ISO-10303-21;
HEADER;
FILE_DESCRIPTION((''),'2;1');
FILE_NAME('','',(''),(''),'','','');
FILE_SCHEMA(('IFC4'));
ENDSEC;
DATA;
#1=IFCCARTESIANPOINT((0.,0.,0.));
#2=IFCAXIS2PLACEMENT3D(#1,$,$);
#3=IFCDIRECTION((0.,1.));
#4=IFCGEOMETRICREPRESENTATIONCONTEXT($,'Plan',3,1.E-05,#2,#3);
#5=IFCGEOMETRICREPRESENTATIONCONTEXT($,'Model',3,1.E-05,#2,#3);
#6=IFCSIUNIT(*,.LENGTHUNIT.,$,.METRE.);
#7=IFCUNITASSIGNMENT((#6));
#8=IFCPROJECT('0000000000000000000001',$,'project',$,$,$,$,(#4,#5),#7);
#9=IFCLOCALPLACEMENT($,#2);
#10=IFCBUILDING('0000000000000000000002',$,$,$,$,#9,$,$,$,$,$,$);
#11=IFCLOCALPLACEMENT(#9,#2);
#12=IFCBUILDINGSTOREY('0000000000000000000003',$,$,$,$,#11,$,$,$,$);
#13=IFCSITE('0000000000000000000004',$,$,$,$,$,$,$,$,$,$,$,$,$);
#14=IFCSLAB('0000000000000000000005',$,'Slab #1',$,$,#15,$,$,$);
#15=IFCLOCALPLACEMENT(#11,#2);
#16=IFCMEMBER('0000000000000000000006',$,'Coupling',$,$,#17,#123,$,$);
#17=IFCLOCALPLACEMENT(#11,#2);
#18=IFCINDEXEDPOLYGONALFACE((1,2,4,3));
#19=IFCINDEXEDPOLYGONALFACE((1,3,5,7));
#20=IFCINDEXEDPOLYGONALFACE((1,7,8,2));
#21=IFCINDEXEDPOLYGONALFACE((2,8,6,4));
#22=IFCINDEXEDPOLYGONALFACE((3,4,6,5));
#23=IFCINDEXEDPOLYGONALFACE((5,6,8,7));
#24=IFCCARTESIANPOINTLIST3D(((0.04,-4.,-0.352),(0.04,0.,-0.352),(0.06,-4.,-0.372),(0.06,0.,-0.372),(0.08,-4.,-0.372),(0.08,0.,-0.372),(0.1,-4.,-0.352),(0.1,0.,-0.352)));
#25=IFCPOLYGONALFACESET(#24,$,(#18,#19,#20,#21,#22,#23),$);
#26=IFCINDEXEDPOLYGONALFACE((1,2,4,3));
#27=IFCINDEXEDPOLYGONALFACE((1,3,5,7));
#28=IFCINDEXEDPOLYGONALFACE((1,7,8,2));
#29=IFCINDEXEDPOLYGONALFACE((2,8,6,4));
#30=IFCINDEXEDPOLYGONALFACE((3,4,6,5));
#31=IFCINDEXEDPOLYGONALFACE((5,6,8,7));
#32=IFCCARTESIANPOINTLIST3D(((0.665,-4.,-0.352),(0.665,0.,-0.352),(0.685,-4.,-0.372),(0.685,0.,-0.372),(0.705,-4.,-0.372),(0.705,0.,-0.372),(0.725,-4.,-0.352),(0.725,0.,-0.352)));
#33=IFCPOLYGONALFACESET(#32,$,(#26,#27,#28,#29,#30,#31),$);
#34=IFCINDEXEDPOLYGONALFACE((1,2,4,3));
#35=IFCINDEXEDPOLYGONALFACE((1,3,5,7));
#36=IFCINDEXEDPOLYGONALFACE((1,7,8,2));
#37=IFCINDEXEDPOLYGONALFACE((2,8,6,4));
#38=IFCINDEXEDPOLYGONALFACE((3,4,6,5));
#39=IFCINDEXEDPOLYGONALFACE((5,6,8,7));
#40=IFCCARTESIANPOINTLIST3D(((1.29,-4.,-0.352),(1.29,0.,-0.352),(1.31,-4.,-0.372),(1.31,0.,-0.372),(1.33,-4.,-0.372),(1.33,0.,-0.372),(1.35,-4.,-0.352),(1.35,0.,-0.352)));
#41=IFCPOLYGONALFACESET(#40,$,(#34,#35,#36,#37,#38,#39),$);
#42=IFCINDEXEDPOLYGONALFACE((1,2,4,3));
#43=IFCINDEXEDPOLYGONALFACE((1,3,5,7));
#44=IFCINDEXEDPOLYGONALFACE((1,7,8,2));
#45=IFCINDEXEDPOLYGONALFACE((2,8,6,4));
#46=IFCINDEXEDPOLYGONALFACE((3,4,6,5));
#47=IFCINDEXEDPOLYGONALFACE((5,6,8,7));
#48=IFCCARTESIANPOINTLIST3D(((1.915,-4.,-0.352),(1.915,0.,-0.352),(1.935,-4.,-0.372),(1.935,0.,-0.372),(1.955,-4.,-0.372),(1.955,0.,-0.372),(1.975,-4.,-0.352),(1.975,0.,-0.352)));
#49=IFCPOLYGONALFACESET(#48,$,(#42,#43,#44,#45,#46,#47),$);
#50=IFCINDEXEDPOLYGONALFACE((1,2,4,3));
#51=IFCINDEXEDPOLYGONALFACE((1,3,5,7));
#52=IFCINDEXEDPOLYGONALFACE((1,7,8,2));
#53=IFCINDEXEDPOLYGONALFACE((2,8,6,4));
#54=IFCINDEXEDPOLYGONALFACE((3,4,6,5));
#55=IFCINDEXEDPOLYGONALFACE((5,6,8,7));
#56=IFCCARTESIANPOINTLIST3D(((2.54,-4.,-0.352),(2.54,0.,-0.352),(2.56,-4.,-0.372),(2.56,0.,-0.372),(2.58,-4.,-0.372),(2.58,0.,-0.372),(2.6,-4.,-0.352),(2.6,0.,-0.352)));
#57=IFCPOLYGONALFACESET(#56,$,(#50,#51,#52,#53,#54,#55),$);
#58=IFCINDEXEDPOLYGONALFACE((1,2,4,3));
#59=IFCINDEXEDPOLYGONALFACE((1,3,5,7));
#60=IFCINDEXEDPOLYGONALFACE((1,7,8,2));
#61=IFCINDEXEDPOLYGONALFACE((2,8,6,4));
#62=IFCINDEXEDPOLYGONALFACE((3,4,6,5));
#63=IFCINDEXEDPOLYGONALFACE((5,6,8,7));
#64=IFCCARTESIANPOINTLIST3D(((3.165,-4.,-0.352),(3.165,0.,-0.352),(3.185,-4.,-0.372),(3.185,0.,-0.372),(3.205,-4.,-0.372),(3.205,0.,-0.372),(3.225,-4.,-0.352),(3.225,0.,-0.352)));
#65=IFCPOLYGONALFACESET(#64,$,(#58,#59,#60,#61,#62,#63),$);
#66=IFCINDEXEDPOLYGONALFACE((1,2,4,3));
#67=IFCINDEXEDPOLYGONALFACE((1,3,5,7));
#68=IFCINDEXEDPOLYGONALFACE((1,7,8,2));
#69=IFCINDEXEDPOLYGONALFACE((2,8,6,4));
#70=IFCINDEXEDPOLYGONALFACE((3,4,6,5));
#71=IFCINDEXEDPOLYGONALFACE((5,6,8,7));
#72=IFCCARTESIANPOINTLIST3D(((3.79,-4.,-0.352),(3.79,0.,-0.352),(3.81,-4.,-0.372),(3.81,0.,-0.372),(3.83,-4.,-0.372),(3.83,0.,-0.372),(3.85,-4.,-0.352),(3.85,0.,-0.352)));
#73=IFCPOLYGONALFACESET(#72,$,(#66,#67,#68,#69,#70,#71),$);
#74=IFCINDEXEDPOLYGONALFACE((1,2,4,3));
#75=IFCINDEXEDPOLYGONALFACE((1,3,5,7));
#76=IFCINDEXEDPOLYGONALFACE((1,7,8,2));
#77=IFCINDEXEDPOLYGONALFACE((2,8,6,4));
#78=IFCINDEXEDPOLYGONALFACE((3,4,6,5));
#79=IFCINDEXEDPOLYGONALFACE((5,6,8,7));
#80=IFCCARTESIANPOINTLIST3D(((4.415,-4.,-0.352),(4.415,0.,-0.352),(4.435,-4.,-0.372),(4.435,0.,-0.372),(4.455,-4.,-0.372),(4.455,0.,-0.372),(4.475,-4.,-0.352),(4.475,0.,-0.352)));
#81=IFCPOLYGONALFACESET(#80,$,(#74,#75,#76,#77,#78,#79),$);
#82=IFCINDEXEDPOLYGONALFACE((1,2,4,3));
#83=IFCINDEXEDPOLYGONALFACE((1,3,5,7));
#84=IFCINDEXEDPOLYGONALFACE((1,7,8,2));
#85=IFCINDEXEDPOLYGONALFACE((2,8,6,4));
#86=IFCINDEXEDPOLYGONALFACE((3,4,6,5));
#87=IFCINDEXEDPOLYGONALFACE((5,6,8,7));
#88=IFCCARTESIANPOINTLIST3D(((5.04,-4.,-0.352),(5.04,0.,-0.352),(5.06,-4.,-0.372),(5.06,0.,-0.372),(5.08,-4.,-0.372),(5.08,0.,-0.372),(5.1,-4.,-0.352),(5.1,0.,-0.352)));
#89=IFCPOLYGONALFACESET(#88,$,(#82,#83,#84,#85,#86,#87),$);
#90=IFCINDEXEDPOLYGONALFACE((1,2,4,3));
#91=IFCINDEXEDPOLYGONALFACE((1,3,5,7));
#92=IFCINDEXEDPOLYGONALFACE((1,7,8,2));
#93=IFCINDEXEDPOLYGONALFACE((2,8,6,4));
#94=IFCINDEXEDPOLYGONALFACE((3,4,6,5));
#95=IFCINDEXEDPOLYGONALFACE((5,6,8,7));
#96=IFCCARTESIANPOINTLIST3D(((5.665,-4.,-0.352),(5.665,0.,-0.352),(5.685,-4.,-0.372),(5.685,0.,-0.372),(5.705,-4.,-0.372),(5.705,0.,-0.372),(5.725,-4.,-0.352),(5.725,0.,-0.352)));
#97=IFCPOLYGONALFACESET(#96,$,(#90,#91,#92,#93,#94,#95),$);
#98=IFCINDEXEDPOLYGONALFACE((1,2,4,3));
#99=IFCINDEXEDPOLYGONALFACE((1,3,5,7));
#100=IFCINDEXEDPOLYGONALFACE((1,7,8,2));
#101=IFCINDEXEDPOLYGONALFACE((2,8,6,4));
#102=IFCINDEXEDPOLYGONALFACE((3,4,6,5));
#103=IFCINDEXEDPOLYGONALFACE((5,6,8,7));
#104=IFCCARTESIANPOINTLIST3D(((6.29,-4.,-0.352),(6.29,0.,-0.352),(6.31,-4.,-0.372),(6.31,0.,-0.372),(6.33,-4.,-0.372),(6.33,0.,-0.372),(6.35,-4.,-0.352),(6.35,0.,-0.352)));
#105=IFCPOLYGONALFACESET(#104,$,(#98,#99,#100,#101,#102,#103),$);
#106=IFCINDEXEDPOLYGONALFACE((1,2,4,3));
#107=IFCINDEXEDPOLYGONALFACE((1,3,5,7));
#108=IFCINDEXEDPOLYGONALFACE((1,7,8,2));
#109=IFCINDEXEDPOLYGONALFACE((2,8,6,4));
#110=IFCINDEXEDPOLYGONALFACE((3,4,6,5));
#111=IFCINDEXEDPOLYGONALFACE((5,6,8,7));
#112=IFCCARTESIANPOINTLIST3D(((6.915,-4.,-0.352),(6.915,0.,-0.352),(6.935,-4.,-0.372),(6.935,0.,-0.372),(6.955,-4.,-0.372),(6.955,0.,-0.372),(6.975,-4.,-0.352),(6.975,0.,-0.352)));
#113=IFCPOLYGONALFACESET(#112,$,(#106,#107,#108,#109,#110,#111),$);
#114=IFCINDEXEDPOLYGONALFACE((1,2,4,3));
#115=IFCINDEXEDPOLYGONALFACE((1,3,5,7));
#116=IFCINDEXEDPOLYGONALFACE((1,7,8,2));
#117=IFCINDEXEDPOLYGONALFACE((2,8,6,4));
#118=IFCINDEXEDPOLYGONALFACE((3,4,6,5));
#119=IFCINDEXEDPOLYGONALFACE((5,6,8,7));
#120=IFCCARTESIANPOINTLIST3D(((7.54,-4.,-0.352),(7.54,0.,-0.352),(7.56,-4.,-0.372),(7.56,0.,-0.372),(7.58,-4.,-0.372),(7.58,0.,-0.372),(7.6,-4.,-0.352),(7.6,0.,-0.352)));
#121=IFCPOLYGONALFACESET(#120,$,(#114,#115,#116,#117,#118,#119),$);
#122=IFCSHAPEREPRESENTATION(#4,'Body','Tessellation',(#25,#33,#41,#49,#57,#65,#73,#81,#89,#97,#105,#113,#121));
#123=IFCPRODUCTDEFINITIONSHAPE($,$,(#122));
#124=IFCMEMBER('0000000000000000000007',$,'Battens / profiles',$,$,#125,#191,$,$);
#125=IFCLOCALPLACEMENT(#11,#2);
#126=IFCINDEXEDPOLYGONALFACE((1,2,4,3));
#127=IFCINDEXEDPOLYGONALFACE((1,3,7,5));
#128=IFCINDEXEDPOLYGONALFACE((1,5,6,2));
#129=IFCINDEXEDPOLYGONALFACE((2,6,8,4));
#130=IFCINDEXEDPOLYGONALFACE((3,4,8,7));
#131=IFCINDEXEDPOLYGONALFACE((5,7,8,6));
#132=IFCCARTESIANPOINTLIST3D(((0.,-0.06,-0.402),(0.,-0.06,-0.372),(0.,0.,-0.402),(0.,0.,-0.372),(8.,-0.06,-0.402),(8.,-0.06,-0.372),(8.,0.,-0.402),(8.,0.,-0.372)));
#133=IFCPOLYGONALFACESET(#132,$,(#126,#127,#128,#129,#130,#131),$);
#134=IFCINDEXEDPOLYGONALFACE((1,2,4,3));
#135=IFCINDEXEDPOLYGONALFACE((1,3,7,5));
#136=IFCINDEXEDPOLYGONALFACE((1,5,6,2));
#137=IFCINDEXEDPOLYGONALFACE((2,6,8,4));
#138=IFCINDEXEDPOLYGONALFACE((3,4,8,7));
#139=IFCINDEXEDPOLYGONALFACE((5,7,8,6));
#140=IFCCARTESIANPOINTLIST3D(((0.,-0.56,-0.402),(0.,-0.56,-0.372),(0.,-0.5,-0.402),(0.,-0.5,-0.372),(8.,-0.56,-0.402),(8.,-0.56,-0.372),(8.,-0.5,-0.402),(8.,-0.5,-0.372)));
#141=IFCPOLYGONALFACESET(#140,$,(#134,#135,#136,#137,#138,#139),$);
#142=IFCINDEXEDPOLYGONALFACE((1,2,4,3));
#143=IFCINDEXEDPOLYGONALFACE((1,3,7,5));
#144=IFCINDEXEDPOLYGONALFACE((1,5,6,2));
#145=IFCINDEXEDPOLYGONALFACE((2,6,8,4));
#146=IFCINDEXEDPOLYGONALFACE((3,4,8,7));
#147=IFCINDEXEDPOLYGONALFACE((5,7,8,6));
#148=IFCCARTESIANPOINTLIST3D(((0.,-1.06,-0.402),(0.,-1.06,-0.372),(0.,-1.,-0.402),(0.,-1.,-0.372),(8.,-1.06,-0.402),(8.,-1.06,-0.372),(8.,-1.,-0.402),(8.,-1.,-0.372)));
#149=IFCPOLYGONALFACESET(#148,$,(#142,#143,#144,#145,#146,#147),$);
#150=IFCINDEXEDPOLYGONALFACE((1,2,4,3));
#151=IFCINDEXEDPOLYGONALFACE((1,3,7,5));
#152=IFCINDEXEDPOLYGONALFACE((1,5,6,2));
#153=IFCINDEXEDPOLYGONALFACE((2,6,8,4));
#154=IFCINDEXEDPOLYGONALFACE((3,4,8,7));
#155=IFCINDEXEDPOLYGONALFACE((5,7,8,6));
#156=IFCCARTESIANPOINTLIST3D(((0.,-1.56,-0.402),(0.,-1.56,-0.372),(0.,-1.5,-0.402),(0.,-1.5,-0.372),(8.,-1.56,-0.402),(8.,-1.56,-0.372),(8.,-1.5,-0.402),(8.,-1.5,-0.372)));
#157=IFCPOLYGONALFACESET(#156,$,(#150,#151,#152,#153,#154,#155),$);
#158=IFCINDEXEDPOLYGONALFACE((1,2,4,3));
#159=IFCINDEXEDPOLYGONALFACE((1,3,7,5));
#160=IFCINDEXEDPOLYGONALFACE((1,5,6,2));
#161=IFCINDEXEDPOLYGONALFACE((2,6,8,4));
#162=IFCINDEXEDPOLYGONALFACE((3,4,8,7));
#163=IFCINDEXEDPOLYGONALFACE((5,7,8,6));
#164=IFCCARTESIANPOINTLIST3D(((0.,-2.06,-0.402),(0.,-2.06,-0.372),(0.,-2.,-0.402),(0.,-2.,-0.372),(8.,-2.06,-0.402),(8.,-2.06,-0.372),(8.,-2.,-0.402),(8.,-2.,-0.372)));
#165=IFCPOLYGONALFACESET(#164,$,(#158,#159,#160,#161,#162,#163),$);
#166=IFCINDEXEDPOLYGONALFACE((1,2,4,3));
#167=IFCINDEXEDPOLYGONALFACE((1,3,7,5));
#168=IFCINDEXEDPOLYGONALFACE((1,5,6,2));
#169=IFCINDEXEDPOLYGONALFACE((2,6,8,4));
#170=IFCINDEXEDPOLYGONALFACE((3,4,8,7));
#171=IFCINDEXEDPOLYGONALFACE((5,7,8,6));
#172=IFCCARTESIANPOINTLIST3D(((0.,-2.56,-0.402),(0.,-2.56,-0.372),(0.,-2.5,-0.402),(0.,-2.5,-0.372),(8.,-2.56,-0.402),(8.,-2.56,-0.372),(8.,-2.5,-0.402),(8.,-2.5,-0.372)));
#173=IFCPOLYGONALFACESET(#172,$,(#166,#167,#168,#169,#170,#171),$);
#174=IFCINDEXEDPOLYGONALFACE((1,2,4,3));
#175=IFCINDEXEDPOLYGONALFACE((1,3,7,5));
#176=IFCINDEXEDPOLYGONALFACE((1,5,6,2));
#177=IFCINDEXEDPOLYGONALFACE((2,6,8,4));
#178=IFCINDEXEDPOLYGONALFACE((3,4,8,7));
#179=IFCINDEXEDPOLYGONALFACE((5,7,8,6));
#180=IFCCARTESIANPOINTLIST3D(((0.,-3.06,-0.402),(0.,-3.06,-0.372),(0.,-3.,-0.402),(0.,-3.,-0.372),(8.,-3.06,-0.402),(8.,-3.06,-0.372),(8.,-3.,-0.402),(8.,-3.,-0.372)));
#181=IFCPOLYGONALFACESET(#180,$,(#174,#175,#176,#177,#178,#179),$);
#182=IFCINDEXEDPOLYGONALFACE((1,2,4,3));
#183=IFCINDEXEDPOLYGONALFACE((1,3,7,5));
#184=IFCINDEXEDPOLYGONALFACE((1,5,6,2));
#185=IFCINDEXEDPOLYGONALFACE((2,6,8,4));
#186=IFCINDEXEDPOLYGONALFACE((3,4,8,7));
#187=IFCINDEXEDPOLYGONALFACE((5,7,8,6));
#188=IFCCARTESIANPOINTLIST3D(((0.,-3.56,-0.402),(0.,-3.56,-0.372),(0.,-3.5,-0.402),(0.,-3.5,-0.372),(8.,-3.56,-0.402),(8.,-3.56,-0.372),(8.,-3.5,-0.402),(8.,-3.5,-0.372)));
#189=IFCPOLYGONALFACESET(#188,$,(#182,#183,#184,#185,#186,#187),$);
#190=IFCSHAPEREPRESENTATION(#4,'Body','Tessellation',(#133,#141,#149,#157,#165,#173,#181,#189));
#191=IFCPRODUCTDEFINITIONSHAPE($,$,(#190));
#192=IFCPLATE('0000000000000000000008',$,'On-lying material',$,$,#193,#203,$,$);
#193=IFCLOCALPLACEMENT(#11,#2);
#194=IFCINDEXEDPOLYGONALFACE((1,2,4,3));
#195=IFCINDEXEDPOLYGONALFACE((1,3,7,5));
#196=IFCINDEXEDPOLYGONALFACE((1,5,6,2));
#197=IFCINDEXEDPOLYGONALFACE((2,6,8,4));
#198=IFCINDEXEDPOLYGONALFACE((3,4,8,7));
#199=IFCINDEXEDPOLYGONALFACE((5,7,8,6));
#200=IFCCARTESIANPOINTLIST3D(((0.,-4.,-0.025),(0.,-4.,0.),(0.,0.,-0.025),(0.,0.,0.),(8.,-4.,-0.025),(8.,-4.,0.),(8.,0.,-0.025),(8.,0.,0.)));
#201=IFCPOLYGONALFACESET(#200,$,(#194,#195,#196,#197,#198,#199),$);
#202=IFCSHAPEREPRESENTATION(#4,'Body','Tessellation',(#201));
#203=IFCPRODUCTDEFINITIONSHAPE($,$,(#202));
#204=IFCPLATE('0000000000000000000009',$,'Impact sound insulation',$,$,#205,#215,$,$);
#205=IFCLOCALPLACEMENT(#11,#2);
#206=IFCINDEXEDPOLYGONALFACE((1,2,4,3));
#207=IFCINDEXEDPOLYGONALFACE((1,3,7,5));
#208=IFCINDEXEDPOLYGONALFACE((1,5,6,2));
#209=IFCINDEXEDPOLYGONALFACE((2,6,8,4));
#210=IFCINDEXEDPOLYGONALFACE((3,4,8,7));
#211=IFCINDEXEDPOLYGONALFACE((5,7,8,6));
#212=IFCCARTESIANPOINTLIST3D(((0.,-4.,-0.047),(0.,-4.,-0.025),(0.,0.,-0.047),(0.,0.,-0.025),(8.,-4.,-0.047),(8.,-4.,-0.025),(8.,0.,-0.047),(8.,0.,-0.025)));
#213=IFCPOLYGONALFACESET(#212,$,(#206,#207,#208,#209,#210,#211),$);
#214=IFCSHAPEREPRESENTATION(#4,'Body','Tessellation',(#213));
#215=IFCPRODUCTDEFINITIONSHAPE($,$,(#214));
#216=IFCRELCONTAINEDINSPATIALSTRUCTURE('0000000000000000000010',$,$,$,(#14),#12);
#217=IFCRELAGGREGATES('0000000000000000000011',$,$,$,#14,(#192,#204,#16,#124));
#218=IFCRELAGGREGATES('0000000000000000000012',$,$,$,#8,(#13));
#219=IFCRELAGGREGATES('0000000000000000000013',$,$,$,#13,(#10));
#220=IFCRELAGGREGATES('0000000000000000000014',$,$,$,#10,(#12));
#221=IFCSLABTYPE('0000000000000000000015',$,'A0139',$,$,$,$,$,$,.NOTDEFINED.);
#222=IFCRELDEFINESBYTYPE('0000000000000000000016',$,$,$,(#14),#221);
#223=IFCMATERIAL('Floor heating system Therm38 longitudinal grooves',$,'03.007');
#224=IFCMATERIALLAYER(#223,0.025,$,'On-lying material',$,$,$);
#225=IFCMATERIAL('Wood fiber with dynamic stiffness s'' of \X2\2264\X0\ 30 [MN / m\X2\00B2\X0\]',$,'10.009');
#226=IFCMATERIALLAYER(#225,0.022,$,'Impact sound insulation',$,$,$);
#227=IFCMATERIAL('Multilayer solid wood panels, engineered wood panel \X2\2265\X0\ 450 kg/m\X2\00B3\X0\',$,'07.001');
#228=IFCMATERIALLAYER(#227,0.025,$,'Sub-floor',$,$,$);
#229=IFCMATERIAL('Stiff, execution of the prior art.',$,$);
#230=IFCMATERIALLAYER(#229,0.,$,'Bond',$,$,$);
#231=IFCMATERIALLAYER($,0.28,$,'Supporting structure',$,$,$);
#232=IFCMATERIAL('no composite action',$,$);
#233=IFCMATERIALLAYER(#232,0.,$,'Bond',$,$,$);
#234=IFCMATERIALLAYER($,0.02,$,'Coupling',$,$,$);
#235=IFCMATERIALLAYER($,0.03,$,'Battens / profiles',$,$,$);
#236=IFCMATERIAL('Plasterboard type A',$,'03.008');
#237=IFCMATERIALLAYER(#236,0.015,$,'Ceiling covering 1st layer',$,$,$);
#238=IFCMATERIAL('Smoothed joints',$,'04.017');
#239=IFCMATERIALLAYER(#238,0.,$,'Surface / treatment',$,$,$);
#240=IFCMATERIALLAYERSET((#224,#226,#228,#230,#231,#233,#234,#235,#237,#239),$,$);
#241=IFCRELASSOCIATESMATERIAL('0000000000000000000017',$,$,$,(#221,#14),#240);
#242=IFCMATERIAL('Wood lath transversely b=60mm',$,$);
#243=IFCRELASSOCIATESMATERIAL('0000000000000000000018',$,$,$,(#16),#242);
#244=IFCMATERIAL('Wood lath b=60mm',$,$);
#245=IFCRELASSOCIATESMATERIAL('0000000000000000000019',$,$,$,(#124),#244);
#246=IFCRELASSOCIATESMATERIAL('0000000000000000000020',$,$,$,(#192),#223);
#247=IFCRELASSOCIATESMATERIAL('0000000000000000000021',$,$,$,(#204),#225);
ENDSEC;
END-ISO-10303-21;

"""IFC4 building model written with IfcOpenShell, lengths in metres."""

from ifc_helpers import new_model, si_unit, direction, frame, frame_2d, origin, origin_with_axes, place, context, project, spatial, polyline, rectangle, outline, extrude, material, layer, layer_set, type_object, element, aggregate, save


model = new_model("IFC4")

# Units and contexts
plan_context = context("Plan", 3, precision=1e-05, world=origin(), true_north=direction((0.0, 1.0)))
model_context = context("Model", 3, precision=1e-05, world=origin(), true_north=direction((0.0, 1.0)))
ifc_project = project(units=[si_unit("LENGTHUNIT", "METRE")], contexts=[plan_context, model_context])

# Site, building, storey
site = spatial("IfcSite", under=ifc_project)
building_placement = place(None, origin())
building = spatial("IfcBuilding", under=site, at=building_placement)
storey_placement = place(building_placement, origin())
storey = spatial("IfcBuildingStorey", under=building, at=storey_placement)

# Slab, members, plates
ifc_material_1 = material(Name="Floor heating system Therm38 longitudinal grooves", Category="03.007")
ifc_layer_1 = layer(ifc_material_1, 0.025, Name="On-lying material")
ifc_material_2 = material(Name="Wood fiber with dynamic stiffness s' of ≤ 30 [MN / m²]", Category="10.009")
ifc_layer_2 = layer(ifc_material_2, 0.022, Name="Impact sound insulation")
ifc_material_3 = material(Name="Multilayer solid wood panels, engineered wood panel ≥ 450 kg/m³", Category="07.001")
ifc_layer_3 = layer(ifc_material_3, 0.025, Name="Sub-floor")
ifc_material_4 = material(Name="Stiff, execution of the prior art.")
ifc_layer_4 = layer(ifc_material_4, 0.0, Name="Bond")
ifc_layer_5 = layer(None, 0.28, Name="Supporting structure")
ifc_material_5 = material(Name="no composite action")
ifc_layer_6 = layer(ifc_material_5, 0.0, Name="Bond")
ifc_layer_7 = layer(None, 0.02, Name="Coupling")
ifc_layer_8 = layer(None, 0.03, Name="Battens / profiles")
ifc_material_6 = material(Name="Plasterboard type A", Category="03.008")
ifc_layer_9 = layer(ifc_material_6, 0.015, Name="Ceiling covering 1st layer")
ifc_material_7 = material(Name="Smoothed joints", Category="04.017")
ifc_layer_10 = layer(ifc_material_7, 0.0, Name="Surface / treatment")
ifc_layer_set = layer_set([ifc_layer_1, ifc_layer_2, ifc_layer_3, ifc_layer_4, ifc_layer_5, ifc_layer_6, ifc_layer_7, ifc_layer_8, ifc_layer_9, ifc_layer_10])
slab_type = type_object("IfcSlabType", Name="A0139", PredefinedType="NOTDEFINED", material=ifc_layer_set)
slab_placement = place(None, frame((0.0, 0.0, 0.0), z_axis=(0.0, 0.0, -1.0), x_axis=(1.0, 0.0, 0.0)))
slab = element("IfcSlab", 1, at=slab_placement, inside=storey, type_object=slab_type, material=ifc_layer_set, Name="Slab #1")
ifc_material_8 = material(Name="Wood lath transversely b=60mm")
member_1_placement = place(slab_placement, origin())
member_1 = element("IfcMember", 2, at=member_1_placement, material=ifc_material_8, Name="Coupling", context=plan_context, shape_type="SweptSolid", body=[
    extrude(outline(polyline([(0.0, 0.0), (0.06, 0.0), (0.04, 0.02), (0.02, 0.02), (0.0, 0.0)])), frame((0.04, 4.0, 0.352), z_axis=(0.0, -1.0, 0.0), x_axis=(1.0, 0.0, 0.0)), (0.0, 0.0, 1.0), 4.0),
    extrude(outline(polyline([(0.0, 0.0), (0.06, 0.0), (0.04, 0.02), (0.02, 0.02), (0.0, 0.0)])), frame((0.665, 4.0, 0.352), z_axis=(0.0, -1.0, 0.0), x_axis=(1.0, 0.0, 0.0)), (0.0, 0.0, 1.0), 4.0),
    extrude(outline(polyline([(0.0, 0.0), (0.06, 0.0), (0.04, 0.02), (0.02, 0.02), (0.0, 0.0)])), frame((1.29, 4.0, 0.352), z_axis=(0.0, -1.0, 0.0), x_axis=(1.0, 0.0, 0.0)), (0.0, 0.0, 1.0), 4.0),
    extrude(outline(polyline([(0.0, 0.0), (0.06, 0.0), (0.04, 0.02), (0.02, 0.02), (0.0, 0.0)])), frame((1.915, 4.0, 0.352), z_axis=(0.0, -1.0, 0.0), x_axis=(1.0, 0.0, 0.0)), (0.0, 0.0, 1.0), 4.0),
    extrude(outline(polyline([(0.0, 0.0), (0.06, 0.0), (0.04, 0.02), (0.02, 0.02), (0.0, 0.0)])), frame((2.54, 4.0, 0.352), z_axis=(0.0, -1.0, 0.0), x_axis=(1.0, 0.0, 0.0)), (0.0, 0.0, 1.0), 4.0),
    extrude(outline(polyline([(0.0, 0.0), (0.06, 0.0), (0.04, 0.02), (0.02, 0.02), (0.0, 0.0)])), frame((3.165, 4.0, 0.352), z_axis=(0.0, -1.0, 0.0), x_axis=(1.0, 0.0, 0.0)), (0.0, 0.0, 1.0), 4.0),
    extrude(outline(polyline([(0.0, 0.0), (0.06, 0.0), (0.04, 0.02), (0.02, 0.02), (0.0, 0.0)])), frame((3.79, 4.0, 0.352), z_axis=(0.0, -1.0, 0.0), x_axis=(1.0, 0.0, 0.0)), (0.0, 0.0, 1.0), 4.0),
    extrude(outline(polyline([(0.0, 0.0), (0.06, 0.0), (0.04, 0.02), (0.02, 0.02), (0.0, 0.0)])), frame((4.415, 4.0, 0.352), z_axis=(0.0, -1.0, 0.0), x_axis=(1.0, 0.0, 0.0)), (0.0, 0.0, 1.0), 4.0),
    extrude(outline(polyline([(0.0, 0.0), (0.06, 0.0), (0.04, 0.02), (0.02, 0.02), (0.0, 0.0)])), frame((5.04, 4.0, 0.352), z_axis=(0.0, -1.0, 0.0), x_axis=(1.0, 0.0, 0.0)), (0.0, 0.0, 1.0), 4.0),
    extrude(outline(polyline([(0.0, 0.0), (0.06, 0.0), (0.04, 0.02), (0.02, 0.02), (0.0, 0.0)])), frame((5.665, 4.0, 0.352), z_axis=(0.0, -1.0, 0.0), x_axis=(1.0, 0.0, 0.0)), (0.0, 0.0, 1.0), 4.0),
    extrude(outline(polyline([(0.0, 0.0), (0.06, 0.0), (0.04, 0.02), (0.02, 0.02), (0.0, 0.0)])), frame((6.29, 4.0, 0.352), z_axis=(0.0, -1.0, 0.0), x_axis=(1.0, 0.0, 0.0)), (0.0, 0.0, 1.0), 4.0),
    extrude(outline(polyline([(0.0, 0.0), (0.06, 0.0), (0.04, 0.02), (0.02, 0.02), (0.0, 0.0)])), frame((6.915, 4.0, 0.352), z_axis=(0.0, -1.0, 0.0), x_axis=(1.0, 0.0, 0.0)), (0.0, 0.0, 1.0), 4.0),
    extrude(outline(polyline([(0.0, 0.0), (0.06, 0.0), (0.04, 0.02), (0.02, 0.02), (0.0, 0.0)])), frame((7.54, 4.0, 0.352), z_axis=(0.0, -1.0, 0.0), x_axis=(1.0, 0.0, 0.0)), (0.0, 0.0, 1.0), 4.0),
])
ifc_material_9 = material(Name="Wood lath b=60mm")
member_2_placement = place(slab_placement, origin())
member_2 = element("IfcMember", 3, at=member_2_placement, material=ifc_material_9, Name="Battens / profiles", context=plan_context, shape_type="SweptSolid", body=[
    extrude(rectangle(XDim=0.06, YDim=0.03, at=frame_2d((0.03, 0.015), x_axis=(1.0, 0.0))), frame((0.0, 0.0, 0.372), z_axis=(1.0, 0.0, 0.0), x_axis=(0.0, 1.0, 0.0)), (0.0, 0.0, 1.0), 8.0),
    extrude(rectangle(XDim=0.06, YDim=0.03, at=frame_2d((0.03, 0.015), x_axis=(1.0, 0.0))), frame((0.0, 0.5, 0.372), z_axis=(1.0, 0.0, 0.0), x_axis=(0.0, 1.0, 0.0)), (0.0, 0.0, 1.0), 8.0),
    extrude(rectangle(XDim=0.06, YDim=0.03, at=frame_2d((0.03, 0.015), x_axis=(1.0, 0.0))), frame((0.0, 1.0, 0.372), z_axis=(1.0, 0.0, 0.0), x_axis=(0.0, 1.0, 0.0)), (0.0, 0.0, 1.0), 8.0),
    extrude(rectangle(XDim=0.06, YDim=0.03, at=frame_2d((0.03, 0.015), x_axis=(1.0, 0.0))), frame((0.0, 1.5, 0.372), z_axis=(1.0, 0.0, 0.0), x_axis=(0.0, 1.0, 0.0)), (0.0, 0.0, 1.0), 8.0),
    extrude(rectangle(XDim=0.06, YDim=0.03, at=frame_2d((0.03, 0.015), x_axis=(1.0, 0.0))), frame((0.0, 2.0, 0.372), z_axis=(1.0, 0.0, 0.0), x_axis=(0.0, 1.0, 0.0)), (0.0, 0.0, 1.0), 8.0),
    extrude(rectangle(XDim=0.06, YDim=0.03, at=frame_2d((0.03, 0.015), x_axis=(1.0, 0.0))), frame((0.0, 2.5, 0.372), z_axis=(1.0, 0.0, 0.0), x_axis=(0.0, 1.0, 0.0)), (0.0, 0.0, 1.0), 8.0),
    extrude(rectangle(XDim=0.06, YDim=0.03, at=frame_2d((0.03, 0.015), x_axis=(1.0, 0.0))), frame((0.0, 3.0, 0.372), z_axis=(1.0, 0.0, 0.0), x_axis=(0.0, 1.0, 0.0)), (0.0, 0.0, 1.0), 8.0),
    extrude(rectangle(XDim=0.06, YDim=0.03, at=frame_2d((0.03, 0.015), x_axis=(1.0, 0.0))), frame((0.0, 3.5, 0.372), z_axis=(1.0, 0.0, 0.0), x_axis=(0.0, 1.0, 0.0)), (0.0, 0.0, 1.0), 8.0),
])
plate_1_placement = place(slab_placement, origin())
plate_1 = element("IfcPlate", 4, at=plate_1_placement, material=ifc_material_1, Name="On-lying material", context=plan_context, shape_type="SweptSolid", body=[
    extrude(rectangle(XDim=8.0, YDim=4.0, at=frame_2d((4.0, 2.0), x_axis=(1.0, 0.0))), origin_with_axes(), (0.0, 0.0, 1.0), 0.025),
])
plate_2_placement = place(slab_placement, origin())
plate_2 = element("IfcPlate", 5, at=plate_2_placement, material=ifc_material_2, Name="Impact sound insulation", context=plan_context, shape_type="SweptSolid", body=[
    extrude(rectangle(XDim=8.0, YDim=4.0, at=frame_2d((4.0, 2.0), x_axis=(1.0, 0.0))), frame((0.0, 0.0, 0.025), z_axis=(0.0, 0.0, 1.0), x_axis=(1.0, 0.0, 0.0)), (0.0, 0.0, 1.0), 0.022),
])
aggregate(slab, [plate_1, plate_2, member_1, member_2])

save(model, "model.ifc")
